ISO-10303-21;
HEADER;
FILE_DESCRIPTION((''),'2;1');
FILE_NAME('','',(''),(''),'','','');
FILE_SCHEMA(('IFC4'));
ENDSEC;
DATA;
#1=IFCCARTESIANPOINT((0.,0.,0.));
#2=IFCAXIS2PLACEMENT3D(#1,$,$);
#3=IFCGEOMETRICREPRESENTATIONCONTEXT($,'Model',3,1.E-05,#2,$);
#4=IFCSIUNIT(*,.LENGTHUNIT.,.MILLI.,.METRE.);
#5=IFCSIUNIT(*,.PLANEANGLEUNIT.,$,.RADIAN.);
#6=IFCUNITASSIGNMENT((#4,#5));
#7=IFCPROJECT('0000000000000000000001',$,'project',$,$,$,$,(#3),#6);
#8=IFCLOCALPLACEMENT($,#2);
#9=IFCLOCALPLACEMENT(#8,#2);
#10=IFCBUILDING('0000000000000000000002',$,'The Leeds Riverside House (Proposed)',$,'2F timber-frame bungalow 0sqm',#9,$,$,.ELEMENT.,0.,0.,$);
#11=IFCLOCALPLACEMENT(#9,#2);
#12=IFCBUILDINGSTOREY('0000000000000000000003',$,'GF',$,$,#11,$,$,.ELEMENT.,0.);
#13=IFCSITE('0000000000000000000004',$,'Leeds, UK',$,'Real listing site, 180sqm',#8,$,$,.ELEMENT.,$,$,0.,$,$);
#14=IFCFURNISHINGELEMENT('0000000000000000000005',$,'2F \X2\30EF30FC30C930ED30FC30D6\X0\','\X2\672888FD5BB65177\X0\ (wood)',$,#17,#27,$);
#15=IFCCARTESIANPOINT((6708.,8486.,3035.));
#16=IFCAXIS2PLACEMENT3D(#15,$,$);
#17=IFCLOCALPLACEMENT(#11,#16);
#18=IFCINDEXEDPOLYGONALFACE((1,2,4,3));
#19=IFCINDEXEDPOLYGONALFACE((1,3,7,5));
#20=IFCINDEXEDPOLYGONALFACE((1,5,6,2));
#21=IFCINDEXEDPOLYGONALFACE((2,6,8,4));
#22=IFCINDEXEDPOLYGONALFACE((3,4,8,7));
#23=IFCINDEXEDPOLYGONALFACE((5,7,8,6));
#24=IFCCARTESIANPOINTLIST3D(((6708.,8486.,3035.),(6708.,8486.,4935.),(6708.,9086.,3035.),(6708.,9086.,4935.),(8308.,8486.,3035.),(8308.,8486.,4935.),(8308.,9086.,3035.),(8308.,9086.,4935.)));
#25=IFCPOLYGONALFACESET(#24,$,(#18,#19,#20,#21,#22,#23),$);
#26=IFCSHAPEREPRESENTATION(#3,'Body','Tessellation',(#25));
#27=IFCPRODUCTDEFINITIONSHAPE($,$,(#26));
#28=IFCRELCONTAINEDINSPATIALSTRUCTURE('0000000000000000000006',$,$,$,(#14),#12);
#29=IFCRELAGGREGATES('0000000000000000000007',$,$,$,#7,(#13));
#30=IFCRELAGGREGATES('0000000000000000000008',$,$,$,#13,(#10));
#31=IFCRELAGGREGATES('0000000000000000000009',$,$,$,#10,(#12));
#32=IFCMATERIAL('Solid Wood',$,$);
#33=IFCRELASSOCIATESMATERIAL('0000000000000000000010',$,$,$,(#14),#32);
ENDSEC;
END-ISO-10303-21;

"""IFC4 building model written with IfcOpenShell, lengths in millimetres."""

from ifc_helpers import new_model, si_unit, frame, frame_2d, origin, place, context, project, spatial, rectangle, extrude, material, element, save


model = new_model("IFC4")

# Units and contexts
model_context = context("Model", 3, precision=1e-05, world=origin())
ifc_project = project(units=[si_unit("LENGTHUNIT", "METRE", prefix="MILLI"), si_unit("PLANEANGLEUNIT", "RADIAN")], contexts=[model_context])

# Site, building, storey
site_placement = place(None, origin())
site = spatial("IfcSite", under=ifc_project, at=site_placement, Name="Leeds, UK", ObjectType="Real listing site, 180sqm", CompositionType="ELEMENT", RefElevation=0.0)
building_placement = place(site_placement, origin())
building = spatial("IfcBuilding", under=site, at=building_placement, Name="The Leeds Riverside House (Proposed)", ObjectType="2F timber-frame bungalow 0sqm", CompositionType="ELEMENT", ElevationOfRefHeight=0.0, ElevationOfTerrain=0.0)
storey_placement = place(building_placement, origin())
storey = spatial("IfcBuildingStorey", under=building, at=storey_placement, Name="GF", CompositionType="ELEMENT", Elevation=0.0)

# Shared definitions
ifc_material_1 = material(Name="Solid Wood")

# Furnishing element
furnishing_1_placement = place(storey_placement, frame((6708.0, 8486.0, 3035.0)))
element("IfcFurnishingElement", 1, at=furnishing_1_placement, inside=storey, material=ifc_material_1, Name="2F ワードローブ", Description="木製家具 (wood)", context=model_context, shape_type="SweptSolid", body=[
    extrude(rectangle(XDim=1600.0, YDim=600.0, at=frame_2d((800.0, 300.0))), frame((6708.0, 8486.0, 3035.0)), (0.0, 0.0, 1.0), 1900.0),
])

save(model, "model.ifc")
